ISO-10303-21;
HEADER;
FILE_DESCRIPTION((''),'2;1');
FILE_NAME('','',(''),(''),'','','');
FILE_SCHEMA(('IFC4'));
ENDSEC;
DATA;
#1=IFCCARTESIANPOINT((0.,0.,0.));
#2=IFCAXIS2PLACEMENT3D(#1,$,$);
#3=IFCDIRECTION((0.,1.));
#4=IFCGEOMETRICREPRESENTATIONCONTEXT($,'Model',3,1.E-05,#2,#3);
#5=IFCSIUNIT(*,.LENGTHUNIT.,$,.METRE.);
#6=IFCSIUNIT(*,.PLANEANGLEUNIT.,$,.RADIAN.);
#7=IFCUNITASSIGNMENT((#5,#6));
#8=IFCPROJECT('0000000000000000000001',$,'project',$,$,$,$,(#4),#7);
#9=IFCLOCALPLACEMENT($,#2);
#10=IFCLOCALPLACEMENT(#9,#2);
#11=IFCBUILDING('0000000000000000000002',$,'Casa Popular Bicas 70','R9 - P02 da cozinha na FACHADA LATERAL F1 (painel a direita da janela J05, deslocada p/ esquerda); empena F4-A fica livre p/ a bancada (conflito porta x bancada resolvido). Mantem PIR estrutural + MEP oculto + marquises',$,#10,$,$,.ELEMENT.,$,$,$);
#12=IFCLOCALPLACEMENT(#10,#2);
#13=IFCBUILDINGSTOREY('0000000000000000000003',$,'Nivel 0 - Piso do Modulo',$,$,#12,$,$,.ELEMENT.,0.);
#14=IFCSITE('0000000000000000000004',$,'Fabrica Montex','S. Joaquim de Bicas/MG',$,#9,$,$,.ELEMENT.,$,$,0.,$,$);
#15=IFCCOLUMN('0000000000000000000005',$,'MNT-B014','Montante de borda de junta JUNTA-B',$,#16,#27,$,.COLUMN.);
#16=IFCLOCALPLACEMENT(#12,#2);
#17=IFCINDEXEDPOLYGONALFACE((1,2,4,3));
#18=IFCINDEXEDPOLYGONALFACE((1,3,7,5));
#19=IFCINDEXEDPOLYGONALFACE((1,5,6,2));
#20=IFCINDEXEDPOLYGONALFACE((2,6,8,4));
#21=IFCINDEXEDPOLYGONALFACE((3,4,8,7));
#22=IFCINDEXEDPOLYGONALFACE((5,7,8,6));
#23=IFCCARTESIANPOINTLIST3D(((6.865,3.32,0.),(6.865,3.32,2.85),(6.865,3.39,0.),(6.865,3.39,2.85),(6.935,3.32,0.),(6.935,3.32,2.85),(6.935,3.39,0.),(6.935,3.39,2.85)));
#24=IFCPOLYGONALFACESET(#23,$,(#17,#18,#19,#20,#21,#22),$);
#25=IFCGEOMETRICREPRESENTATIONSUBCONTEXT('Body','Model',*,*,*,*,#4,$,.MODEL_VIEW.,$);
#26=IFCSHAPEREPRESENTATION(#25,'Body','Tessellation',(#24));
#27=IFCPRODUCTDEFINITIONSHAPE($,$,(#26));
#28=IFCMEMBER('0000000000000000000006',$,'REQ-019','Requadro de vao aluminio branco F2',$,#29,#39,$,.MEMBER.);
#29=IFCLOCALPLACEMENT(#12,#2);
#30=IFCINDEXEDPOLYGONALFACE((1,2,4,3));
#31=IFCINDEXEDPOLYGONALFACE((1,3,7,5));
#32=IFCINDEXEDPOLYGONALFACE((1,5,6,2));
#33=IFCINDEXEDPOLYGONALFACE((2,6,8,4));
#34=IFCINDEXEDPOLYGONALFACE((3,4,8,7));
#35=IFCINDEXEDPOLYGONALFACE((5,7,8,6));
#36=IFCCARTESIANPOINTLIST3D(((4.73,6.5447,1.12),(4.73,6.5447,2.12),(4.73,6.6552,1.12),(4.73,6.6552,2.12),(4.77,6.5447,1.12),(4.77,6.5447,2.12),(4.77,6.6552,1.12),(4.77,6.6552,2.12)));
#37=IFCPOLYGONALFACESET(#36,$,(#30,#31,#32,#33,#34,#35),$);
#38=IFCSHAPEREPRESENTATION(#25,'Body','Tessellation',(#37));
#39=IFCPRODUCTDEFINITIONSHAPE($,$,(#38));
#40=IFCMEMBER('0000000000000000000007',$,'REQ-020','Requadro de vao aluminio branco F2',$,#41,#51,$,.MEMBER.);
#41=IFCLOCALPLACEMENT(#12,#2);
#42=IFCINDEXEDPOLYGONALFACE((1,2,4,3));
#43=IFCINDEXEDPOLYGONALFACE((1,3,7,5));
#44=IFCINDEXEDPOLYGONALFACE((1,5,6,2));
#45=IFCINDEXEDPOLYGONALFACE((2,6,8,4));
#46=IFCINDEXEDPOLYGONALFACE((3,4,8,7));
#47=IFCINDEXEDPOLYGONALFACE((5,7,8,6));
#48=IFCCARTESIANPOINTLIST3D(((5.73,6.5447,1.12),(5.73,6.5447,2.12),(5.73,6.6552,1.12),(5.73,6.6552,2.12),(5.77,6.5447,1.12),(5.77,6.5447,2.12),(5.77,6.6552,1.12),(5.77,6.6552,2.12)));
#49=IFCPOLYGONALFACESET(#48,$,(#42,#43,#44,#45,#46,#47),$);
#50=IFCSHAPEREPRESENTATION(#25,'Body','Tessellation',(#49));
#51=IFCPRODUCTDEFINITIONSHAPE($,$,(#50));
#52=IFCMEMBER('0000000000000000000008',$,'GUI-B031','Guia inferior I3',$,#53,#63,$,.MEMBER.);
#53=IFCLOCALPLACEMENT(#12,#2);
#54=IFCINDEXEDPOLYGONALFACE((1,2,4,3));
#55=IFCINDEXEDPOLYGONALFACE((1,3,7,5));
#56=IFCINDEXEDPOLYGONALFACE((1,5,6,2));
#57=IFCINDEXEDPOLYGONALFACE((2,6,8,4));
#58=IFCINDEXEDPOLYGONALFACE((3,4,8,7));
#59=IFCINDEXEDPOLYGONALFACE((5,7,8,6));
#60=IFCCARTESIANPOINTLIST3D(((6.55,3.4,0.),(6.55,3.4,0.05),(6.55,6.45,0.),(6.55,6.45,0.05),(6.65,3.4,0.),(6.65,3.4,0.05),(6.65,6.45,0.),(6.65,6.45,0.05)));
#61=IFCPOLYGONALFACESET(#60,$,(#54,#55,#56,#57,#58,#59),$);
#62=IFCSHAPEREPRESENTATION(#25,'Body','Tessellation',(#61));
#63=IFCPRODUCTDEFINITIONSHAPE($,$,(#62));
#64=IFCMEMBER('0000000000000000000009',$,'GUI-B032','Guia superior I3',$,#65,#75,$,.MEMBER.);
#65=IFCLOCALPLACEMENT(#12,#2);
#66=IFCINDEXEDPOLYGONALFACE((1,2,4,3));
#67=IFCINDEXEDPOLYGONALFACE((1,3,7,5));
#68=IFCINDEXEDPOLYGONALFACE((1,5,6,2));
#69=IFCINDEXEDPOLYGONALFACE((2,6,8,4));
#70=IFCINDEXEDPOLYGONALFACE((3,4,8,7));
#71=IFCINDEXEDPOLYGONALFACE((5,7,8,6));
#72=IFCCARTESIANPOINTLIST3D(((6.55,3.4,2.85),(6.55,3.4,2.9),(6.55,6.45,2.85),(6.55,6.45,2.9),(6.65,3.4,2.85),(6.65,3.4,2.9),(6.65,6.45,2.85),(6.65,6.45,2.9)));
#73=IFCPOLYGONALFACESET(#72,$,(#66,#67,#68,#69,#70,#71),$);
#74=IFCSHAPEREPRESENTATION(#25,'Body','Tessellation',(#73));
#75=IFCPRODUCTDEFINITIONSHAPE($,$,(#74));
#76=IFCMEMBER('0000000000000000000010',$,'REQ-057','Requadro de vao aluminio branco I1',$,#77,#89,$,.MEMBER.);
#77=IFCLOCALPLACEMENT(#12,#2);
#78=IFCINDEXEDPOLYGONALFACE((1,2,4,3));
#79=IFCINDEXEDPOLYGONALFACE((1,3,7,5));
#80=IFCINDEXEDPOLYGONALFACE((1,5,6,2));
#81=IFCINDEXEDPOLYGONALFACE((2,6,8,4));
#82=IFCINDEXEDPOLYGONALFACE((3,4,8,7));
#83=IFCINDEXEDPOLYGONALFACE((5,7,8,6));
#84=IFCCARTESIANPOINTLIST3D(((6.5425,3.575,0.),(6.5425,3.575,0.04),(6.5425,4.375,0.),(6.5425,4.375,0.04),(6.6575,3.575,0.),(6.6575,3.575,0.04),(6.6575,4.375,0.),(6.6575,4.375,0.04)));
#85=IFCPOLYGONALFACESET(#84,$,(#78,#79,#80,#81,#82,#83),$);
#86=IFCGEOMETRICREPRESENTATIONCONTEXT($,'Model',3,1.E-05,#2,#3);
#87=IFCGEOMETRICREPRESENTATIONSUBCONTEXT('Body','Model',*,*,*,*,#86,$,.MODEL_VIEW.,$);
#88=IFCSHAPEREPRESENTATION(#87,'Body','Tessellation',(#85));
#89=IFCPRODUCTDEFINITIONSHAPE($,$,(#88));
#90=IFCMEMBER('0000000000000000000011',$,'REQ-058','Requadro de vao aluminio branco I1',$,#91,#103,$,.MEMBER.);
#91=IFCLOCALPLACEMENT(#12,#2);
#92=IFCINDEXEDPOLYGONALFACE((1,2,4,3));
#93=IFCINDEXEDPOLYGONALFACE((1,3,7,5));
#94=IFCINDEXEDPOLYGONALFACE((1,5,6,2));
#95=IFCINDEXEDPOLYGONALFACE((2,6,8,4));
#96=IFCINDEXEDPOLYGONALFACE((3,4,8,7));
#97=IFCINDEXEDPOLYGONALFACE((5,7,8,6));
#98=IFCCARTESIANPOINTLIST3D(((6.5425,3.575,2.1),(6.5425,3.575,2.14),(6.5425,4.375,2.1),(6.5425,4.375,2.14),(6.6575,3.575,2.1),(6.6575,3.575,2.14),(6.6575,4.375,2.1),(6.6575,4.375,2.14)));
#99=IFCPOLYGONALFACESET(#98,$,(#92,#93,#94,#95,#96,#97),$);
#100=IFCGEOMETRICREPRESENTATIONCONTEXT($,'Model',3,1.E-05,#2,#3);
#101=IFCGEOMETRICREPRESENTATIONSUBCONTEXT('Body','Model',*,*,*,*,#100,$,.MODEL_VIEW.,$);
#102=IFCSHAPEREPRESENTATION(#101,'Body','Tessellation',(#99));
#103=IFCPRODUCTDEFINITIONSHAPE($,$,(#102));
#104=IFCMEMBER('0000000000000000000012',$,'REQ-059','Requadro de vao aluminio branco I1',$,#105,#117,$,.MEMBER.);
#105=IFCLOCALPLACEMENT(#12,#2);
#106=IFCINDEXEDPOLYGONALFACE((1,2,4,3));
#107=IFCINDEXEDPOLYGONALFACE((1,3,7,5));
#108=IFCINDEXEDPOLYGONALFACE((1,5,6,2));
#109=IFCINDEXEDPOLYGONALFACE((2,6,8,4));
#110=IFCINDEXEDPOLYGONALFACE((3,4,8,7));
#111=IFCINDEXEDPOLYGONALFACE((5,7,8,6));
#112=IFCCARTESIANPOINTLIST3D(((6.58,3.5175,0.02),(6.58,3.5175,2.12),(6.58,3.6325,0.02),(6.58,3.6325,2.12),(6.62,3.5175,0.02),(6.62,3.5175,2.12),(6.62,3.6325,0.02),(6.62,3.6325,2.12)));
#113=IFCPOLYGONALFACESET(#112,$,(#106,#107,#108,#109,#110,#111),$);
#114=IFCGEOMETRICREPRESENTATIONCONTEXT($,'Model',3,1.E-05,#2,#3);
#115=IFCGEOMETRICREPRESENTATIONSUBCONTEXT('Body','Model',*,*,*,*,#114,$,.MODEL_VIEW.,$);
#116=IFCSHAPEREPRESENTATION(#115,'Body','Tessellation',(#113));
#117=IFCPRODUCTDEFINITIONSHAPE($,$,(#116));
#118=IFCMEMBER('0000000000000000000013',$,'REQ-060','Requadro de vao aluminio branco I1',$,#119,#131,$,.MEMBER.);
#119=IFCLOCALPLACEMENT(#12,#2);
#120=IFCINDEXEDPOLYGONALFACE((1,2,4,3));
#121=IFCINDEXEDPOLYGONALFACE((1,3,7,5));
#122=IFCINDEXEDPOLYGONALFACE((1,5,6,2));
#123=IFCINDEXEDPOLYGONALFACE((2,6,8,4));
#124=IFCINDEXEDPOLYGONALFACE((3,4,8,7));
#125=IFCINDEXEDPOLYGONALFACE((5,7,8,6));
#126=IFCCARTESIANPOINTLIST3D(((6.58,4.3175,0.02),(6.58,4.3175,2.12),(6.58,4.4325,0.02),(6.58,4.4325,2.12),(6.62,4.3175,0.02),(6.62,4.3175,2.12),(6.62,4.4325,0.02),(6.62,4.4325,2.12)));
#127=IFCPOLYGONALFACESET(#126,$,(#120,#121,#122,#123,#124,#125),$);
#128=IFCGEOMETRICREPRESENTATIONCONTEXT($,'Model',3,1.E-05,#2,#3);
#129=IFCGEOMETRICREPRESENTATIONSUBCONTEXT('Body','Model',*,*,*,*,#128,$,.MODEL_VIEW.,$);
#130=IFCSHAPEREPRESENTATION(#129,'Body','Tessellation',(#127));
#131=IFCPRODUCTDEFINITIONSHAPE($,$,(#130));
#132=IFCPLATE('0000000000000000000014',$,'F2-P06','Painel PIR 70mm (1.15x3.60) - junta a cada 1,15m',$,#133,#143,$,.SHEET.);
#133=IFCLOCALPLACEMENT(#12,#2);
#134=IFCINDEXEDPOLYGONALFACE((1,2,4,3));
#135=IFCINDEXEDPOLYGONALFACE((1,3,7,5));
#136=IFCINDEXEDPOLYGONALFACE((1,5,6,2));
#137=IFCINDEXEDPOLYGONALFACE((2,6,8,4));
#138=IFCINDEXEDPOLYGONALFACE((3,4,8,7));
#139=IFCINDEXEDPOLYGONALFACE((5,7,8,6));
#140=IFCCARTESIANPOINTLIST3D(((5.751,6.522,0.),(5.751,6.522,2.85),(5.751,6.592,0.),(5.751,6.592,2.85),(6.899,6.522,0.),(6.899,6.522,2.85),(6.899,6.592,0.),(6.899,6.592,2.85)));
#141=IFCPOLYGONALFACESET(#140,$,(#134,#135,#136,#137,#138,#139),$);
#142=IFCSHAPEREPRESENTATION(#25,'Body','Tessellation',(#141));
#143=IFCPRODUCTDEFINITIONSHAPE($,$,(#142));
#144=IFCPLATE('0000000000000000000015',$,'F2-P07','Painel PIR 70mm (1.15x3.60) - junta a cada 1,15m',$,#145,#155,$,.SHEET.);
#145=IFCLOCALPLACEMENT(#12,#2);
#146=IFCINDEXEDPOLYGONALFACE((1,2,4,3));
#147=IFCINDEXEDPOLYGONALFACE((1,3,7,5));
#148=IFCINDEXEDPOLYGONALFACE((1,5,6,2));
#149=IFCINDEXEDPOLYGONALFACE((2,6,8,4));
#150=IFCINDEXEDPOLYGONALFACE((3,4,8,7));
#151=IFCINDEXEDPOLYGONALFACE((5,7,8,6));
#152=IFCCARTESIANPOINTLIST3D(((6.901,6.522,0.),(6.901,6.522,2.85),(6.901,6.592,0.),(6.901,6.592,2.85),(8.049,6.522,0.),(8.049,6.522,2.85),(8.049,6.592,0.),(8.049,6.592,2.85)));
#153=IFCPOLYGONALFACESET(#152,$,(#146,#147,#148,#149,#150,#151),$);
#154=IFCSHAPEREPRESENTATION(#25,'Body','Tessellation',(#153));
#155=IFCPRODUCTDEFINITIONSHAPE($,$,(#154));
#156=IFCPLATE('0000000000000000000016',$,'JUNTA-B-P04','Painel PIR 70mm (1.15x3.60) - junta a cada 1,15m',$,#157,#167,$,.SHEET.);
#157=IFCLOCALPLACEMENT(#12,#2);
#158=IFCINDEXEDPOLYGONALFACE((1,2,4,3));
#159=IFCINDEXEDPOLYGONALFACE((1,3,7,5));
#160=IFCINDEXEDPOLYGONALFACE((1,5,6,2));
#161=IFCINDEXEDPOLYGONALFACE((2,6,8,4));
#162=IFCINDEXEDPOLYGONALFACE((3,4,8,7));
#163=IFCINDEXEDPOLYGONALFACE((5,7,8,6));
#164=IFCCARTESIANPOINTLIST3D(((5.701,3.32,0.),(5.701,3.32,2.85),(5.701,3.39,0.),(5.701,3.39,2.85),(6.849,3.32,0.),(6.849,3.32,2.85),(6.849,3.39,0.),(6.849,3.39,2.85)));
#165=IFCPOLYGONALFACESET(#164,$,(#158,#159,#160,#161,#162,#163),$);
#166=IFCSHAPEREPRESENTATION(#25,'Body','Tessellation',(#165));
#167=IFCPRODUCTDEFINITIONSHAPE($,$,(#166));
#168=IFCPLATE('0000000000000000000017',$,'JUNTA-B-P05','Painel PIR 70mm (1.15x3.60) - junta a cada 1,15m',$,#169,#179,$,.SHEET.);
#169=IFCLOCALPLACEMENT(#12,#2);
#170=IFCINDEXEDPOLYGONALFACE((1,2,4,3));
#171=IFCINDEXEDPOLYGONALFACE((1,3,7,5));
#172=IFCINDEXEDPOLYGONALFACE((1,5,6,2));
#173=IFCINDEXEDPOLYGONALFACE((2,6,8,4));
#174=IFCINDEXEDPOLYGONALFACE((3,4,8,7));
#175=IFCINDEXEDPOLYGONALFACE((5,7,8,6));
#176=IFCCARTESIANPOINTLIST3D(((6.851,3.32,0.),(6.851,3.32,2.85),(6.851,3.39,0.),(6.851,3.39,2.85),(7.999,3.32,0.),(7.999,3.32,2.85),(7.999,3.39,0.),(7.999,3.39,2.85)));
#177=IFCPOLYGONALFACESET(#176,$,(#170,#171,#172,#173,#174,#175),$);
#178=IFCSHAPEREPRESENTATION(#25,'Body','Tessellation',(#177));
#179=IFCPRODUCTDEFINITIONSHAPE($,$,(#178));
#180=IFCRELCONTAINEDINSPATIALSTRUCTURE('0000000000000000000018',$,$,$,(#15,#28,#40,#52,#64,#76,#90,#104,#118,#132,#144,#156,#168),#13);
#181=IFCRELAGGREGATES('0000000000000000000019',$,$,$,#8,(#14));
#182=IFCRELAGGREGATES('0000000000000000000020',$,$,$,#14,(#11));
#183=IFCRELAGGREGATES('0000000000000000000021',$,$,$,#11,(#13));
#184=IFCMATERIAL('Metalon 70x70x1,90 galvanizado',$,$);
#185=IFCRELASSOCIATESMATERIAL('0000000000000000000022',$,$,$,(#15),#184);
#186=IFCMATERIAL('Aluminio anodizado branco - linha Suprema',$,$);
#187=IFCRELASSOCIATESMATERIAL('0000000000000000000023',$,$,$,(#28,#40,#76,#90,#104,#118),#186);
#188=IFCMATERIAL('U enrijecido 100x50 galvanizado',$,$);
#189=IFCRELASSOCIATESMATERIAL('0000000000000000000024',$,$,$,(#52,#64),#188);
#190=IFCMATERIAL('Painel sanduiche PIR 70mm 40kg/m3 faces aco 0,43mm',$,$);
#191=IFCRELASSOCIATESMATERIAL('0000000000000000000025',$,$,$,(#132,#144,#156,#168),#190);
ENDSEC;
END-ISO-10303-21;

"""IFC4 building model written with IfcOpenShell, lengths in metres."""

from ifc_helpers import new_model, si_unit, direction, frame, frame_2d, origin, origin_2d, place, context, subcontext, project, spatial, rectangle, extrude, material, element, save


model = new_model("IFC4")

# Units and contexts
model_context_1 = context("Model", 3, precision=1e-05, world=origin(), true_north=direction((0.0, 1.0)))
model_context_2 = context("Model", 3, precision=1e-05, world=origin(), true_north=direction((0.0, 1.0)))
model_context_3 = context("Model", 3, precision=1e-05, world=origin(), true_north=direction((0.0, 1.0)))
model_context_4 = context("Model", 3, precision=1e-05, world=origin(), true_north=direction((0.0, 1.0)))
model_context_5 = context("Model", 3, precision=1e-05, world=origin(), true_north=direction((0.0, 1.0)))
body_context_1 = subcontext(model_context_1, "Body", "Model", "MODEL_VIEW")
body_context_2 = subcontext(model_context_2, "Body", "Model", "MODEL_VIEW")
body_context_3 = subcontext(model_context_3, "Body", "Model", "MODEL_VIEW")
body_context_4 = subcontext(model_context_4, "Body", "Model", "MODEL_VIEW")
body_context_5 = subcontext(model_context_5, "Body", "Model", "MODEL_VIEW")
ifc_project = project(units=[si_unit("LENGTHUNIT", "METRE"), si_unit("PLANEANGLEUNIT", "RADIAN")], contexts=[model_context_1])

# Site, building, storey
site_placement = place(None, origin())
site = spatial("IfcSite", under=ifc_project, at=site_placement, Name="Fabrica Montex", Description="S. Joaquim de Bicas/MG", CompositionType="ELEMENT", RefElevation=0.0)
building_placement = place(site_placement, origin())
building = spatial("IfcBuilding", under=site, at=building_placement, Name="Casa Popular Bicas 70", Description="R9 - P02 da cozinha na FACHADA LATERAL F1 (painel a direita da janela J05, deslocada p/ esquerda); empena F4-A fica livre p/ a bancada (conflito porta x bancada resolvido). Mantem PIR estrutural + MEP oculto + marquises", CompositionType="ELEMENT")
storey_placement = place(building_placement, origin())
storey = spatial("IfcBuildingStorey", under=building, at=storey_placement, Name="Nivel 0 - Piso do Modulo", CompositionType="ELEMENT", Elevation=0.0)

# Column
ifc_material_1 = material(Name="Metalon 70x70x1,90 galvanizado")
column_placement = place(storey_placement, frame((6.9, 3.355, 0.0)))
element("IfcColumn", 1, at=column_placement, inside=storey, material=ifc_material_1, Name="MNT-B014", Description="Montante de borda de junta JUNTA-B", PredefinedType="COLUMN", context=body_context_1, shape_type="SweptSolid", body=[
    extrude(rectangle(XDim=0.07, YDim=0.07, at=origin_2d()), origin(), (0.0, 0.0, 1.0), 2.85),
])

# Members
ifc_material_2 = material(Name="Aluminio anodizado branco - linha Suprema")
for number, where, z_axis, x_axis, name in (
    (2, (4.75, 6.6, 1.12), (0.0, 0.0, 1.0), (1.0, 0.0, 0.0), "REQ-019"),
    (3, (5.75, 6.6, 1.12), (0.0, 0.0, 1.0), (1.0, 0.0, 0.0), "REQ-020"),
):
    element("IfcMember", number, at=place(storey_placement, frame(where, z_axis=z_axis, x_axis=x_axis)), inside=storey, material=ifc_material_2, Name=name, Description="Requadro de vao aluminio branco F2", PredefinedType="MEMBER", context=body_context_1, shape_type="SweptSolid", body=[
        extrude(rectangle(XDim=0.04, YDim=0.1105, at=origin_2d()), origin(), (0.0, 0.0, 1.0), 1.0),
    ])
ifc_material_3 = material(Name="U enrijecido 100x50 galvanizado")
for number, where, z_axis, x_axis, name, description in (
    (4, (6.6, 3.4, 0.025), (0.0, 1.0, 0.0), (0.0, 0.0, 1.0), "GUI-B031", "Guia inferior I3"),
    (5, (6.6, 3.4, 2.875), (0.0, 1.0, 0.0), (0.0, 0.0, 1.0), "GUI-B032", "Guia superior I3"),
):
    element("IfcMember", number, at=place(storey_placement, frame(where, z_axis=z_axis, x_axis=x_axis)), inside=storey, material=ifc_material_3, Name=name, Description=description, PredefinedType="MEMBER", context=body_context_1, shape_type="SweptSolid", body=[
        extrude(rectangle(XDim=0.05, YDim=0.1, at=origin_2d()), origin(), (0.0, 0.0, 1.0), 3.05),
    ])
placement_1 = place(None, origin())
placement_2 = place(placement_1, origin())
placement_3 = place(placement_2, origin())
member_1_placement = place(placement_3, frame((6.6, 3.575, 0.02), z_axis=(0.0, 1.0, 0.0), x_axis=(0.0, 0.0, 1.0)))
element("IfcMember", 6, at=member_1_placement, inside=storey, material=ifc_material_2, Name="REQ-057", Description="Requadro de vao aluminio branco I1", PredefinedType="MEMBER", context=body_context_2, shape_type="SweptSolid", body=[
    extrude(rectangle(XDim=0.04, YDim=0.115, at=origin_2d()), origin(), (0.0, 0.0, 1.0), 0.8),
])
placement_4 = place(None, origin())
placement_5 = place(placement_4, origin())
placement_6 = place(placement_5, origin())
member_2_placement = place(placement_6, frame((6.6, 3.575, 2.12), z_axis=(0.0, 1.0, 0.0), x_axis=(0.0, 0.0, 1.0)))
element("IfcMember", 7, at=member_2_placement, inside=storey, material=ifc_material_2, Name="REQ-058", Description="Requadro de vao aluminio branco I1", PredefinedType="MEMBER", context=body_context_3, shape_type="SweptSolid", body=[
    extrude(rectangle(XDim=0.04, YDim=0.115, at=origin_2d()), origin(), (0.0, 0.0, 1.0), 0.8),
])
placement_7 = place(None, origin())
placement_8 = place(placement_7, origin())
placement_9 = place(placement_8, origin())
member_3_placement = place(placement_9, frame((6.6, 3.575, 0.02), z_axis=(0.0, 0.0, 1.0), x_axis=(1.0, 0.0, 0.0)))
element("IfcMember", 8, at=member_3_placement, inside=storey, material=ifc_material_2, Name="REQ-059", Description="Requadro de vao aluminio branco I1", PredefinedType="MEMBER", context=body_context_4, shape_type="SweptSolid", body=[
    extrude(rectangle(XDim=0.04, YDim=0.115, at=origin_2d()), origin(), (0.0, 0.0, 1.0), 2.1),
])
placement_10 = place(None, origin())
placement_11 = place(placement_10, origin())
placement_12 = place(placement_11, origin())
member_4_placement = place(placement_12, frame((6.6, 4.375, 0.02), z_axis=(0.0, 0.0, 1.0), x_axis=(1.0, 0.0, 0.0)))
element("IfcMember", 9, at=member_4_placement, inside=storey, material=ifc_material_2, Name="REQ-060", Description="Requadro de vao aluminio branco I1", PredefinedType="MEMBER", context=body_context_5, shape_type="SweptSolid", body=[
    extrude(rectangle(XDim=0.04, YDim=0.115, at=origin_2d()), origin(), (0.0, 0.0, 1.0), 2.1),
])

# Plates
ifc_material_4 = material(Name="Painel sanduiche PIR 70mm 40kg/m3 faces aco 0,43mm")
for number, where, x_axis, name in (
    (10, (5.751, 6.557, 0.0), (1.0, 0.0, 0.0), "F2-P06"),
    (11, (6.901, 6.557, 0.0), (1.0, 0.0, 0.0), "F2-P07"),
    (12, (5.701, 3.355, 0.0), (1.0, 0.0, 0.0), "JUNTA-B-P04"),
    (13, (6.851, 3.355, 0.0), (1.0, 0.0, 0.0), "JUNTA-B-P05"),
):
    element("IfcPlate", number, at=place(storey_placement, frame(where, x_axis=x_axis)), inside=storey, material=ifc_material_4, Name=name, Description="Painel PIR 70mm (1.15x3.60) - junta a cada 1,15m", PredefinedType="SHEET", context=body_context_1, shape_type="SweptSolid", body=[
        extrude(rectangle(XDim=1.148, YDim=0.07, at=frame_2d((0.574, 0.0))), origin(), (0.0, 0.0, 1.0), 2.85),
    ])

save(model, "model.ifc")
